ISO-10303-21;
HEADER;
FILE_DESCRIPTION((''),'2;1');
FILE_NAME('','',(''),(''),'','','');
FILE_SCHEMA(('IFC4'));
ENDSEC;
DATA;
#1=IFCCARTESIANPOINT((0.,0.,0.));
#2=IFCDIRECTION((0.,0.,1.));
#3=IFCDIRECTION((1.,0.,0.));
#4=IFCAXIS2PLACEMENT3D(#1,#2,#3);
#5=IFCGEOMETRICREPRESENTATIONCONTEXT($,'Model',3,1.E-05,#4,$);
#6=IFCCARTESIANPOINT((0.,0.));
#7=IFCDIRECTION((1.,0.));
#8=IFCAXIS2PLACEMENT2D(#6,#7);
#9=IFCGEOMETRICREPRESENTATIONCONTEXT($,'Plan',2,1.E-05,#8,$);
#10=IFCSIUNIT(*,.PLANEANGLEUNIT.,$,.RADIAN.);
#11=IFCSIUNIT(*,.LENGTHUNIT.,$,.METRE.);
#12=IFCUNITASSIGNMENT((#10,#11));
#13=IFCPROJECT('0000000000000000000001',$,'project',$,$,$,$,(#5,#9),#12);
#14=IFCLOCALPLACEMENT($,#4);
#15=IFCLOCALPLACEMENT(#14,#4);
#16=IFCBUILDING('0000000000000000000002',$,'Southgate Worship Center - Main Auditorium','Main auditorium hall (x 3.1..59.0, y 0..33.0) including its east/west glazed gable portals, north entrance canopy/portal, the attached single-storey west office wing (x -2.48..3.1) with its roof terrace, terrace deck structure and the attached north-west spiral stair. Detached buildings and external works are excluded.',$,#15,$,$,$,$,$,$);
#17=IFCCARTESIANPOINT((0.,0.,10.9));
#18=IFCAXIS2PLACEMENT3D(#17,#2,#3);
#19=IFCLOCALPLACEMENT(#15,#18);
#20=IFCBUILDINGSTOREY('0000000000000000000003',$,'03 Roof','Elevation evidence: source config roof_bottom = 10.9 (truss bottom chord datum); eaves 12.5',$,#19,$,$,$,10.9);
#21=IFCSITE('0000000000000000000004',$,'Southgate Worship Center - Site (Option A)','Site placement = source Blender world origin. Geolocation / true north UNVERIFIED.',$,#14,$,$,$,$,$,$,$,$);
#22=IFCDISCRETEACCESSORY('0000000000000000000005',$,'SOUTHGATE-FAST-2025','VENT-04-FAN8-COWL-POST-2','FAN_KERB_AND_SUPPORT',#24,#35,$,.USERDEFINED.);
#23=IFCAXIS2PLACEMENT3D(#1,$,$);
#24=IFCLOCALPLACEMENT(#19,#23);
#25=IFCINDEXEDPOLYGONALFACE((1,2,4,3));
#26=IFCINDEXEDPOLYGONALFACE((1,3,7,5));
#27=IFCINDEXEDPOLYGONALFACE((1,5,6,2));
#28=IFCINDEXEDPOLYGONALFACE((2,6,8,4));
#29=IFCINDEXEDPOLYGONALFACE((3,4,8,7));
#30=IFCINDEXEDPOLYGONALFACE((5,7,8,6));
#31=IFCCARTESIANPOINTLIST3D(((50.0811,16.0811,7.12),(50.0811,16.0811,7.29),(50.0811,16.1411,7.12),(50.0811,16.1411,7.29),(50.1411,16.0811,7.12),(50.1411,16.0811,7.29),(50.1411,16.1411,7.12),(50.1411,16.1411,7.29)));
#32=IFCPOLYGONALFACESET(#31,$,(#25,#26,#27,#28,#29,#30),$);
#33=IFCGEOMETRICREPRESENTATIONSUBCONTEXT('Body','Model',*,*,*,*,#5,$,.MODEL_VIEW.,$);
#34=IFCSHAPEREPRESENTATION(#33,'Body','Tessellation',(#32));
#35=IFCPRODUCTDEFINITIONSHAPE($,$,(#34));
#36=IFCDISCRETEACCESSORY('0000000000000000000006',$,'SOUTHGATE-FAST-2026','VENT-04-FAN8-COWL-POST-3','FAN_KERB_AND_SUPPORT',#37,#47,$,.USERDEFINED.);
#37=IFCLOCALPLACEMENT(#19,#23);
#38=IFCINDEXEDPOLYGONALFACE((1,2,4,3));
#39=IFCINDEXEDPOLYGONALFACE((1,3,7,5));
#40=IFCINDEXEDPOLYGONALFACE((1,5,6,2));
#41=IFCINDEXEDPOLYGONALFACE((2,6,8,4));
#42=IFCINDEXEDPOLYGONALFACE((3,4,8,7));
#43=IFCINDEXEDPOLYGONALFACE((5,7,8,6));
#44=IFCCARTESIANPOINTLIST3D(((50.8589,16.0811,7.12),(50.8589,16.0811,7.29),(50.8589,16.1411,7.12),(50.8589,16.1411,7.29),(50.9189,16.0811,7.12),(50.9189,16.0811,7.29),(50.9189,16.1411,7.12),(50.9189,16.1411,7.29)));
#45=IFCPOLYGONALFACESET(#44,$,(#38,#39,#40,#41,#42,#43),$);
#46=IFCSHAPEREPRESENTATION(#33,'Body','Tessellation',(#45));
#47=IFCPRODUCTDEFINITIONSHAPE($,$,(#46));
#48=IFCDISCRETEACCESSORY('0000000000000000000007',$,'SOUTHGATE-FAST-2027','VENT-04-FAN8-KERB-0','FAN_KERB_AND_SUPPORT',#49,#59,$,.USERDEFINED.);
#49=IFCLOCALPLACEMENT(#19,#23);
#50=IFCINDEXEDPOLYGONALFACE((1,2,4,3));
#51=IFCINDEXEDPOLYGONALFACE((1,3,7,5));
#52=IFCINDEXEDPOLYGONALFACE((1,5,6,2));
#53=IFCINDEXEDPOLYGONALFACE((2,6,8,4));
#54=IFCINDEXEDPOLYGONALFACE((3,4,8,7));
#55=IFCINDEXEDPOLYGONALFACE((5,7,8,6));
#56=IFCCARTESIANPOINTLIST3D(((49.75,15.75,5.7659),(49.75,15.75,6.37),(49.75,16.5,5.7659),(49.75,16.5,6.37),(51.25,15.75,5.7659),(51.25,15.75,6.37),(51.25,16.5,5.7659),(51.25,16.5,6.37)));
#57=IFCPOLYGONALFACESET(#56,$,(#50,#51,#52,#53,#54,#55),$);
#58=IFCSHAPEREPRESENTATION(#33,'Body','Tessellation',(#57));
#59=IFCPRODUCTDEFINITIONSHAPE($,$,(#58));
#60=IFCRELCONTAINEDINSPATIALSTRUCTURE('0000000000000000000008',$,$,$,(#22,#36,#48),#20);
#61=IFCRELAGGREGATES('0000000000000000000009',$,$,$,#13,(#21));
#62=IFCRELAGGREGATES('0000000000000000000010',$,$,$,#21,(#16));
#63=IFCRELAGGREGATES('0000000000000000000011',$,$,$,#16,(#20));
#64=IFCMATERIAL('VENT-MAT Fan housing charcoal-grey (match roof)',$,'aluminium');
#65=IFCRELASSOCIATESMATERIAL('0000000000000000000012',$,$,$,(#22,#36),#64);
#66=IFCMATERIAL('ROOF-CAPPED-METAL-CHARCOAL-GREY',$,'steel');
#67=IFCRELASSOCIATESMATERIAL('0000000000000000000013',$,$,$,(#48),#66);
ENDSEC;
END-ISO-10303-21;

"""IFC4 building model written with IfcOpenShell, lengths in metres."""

from ifc_helpers import new_model, si_unit, frame, origin_with_axes, origin_2d, origin_2d_with_axis, place, context, subcontext, project, spatial, rectangle, extrude, material, element, save


model = new_model("IFC4")

# Units and contexts
model_context = context("Model", 3, precision=1e-05, world=origin_with_axes())
plan_context = context("Plan", 2, precision=1e-05, world=origin_2d_with_axis())
body_context = subcontext(model_context, "Body", "Model", "MODEL_VIEW")
ifc_project = project(units=[si_unit("PLANEANGLEUNIT", "RADIAN"), si_unit("LENGTHUNIT", "METRE")], contexts=[model_context, plan_context])

# Site, building, storey
site_placement = place(None, origin_with_axes())
site = spatial("IfcSite", under=ifc_project, at=site_placement, Name="Southgate Worship Center - Site (Option A)", Description="Site placement = source Blender world origin. Geolocation / true north UNVERIFIED.")
building_placement = place(site_placement, origin_with_axes())
building = spatial("IfcBuilding", under=site, at=building_placement, Name="Southgate Worship Center - Main Auditorium", Description="Main auditorium hall (x 3.1..59.0, y 0..33.0) including its east/west glazed gable portals, north entrance canopy/portal, the attached single-storey west office wing (x -2.48..3.1) with its roof terrace, terrace deck structure and the attached north-west spiral stair. Detached buildings and external works are excluded.")
storey_placement = place(building_placement, frame((0.0, 0.0, 10.9), z_axis=(0.0, 0.0, 1.0), x_axis=(1.0, 0.0, 0.0)))
storey = spatial("IfcBuildingStorey", under=building, at=storey_placement, Name="03 Roof", Description="Elevation evidence: source config roof_bottom = 10.9 (truss bottom chord datum); eaves 12.5", Elevation=10.9)

# Discrete accessories
ifc_material_1 = material(Name="VENT-MAT Fan housing charcoal-grey (match roof)", Category="aluminium")
discrete_accessory_1_placement = place(storey_placement, frame((50.0811, 16.0811, 7.12), z_axis=(0.0, 0.0, 1.0), x_axis=(1.0, 0.0, 0.0)))
element("IfcDiscreteAccessory", 1, at=discrete_accessory_1_placement, inside=storey, material=ifc_material_1, Name="SOUTHGATE-FAST-2025", Description="VENT-04-FAN8-COWL-POST-2", ObjectType="FAN_KERB_AND_SUPPORT", PredefinedType="USERDEFINED", context=body_context, shape_type="SweptSolid", body=[
    extrude(rectangle(XDim=0.06, YDim=0.06, at=origin_2d()), frame((0.03, 0.03, 0.0), z_axis=(0.0, 0.0, 1.0), x_axis=(0.0, 1.0, 0.0)), (0.0, 0.0, 1.0), 0.17),
])
discrete_accessory_2_placement = place(storey_placement, frame((50.8589, 16.0811, 7.12), z_axis=(0.0, 0.0, 1.0), x_axis=(1.0, 0.0, 0.0)))
element("IfcDiscreteAccessory", 2, at=discrete_accessory_2_placement, inside=storey, material=ifc_material_1, Name="SOUTHGATE-FAST-2026", Description="VENT-04-FAN8-COWL-POST-3", ObjectType="FAN_KERB_AND_SUPPORT", PredefinedType="USERDEFINED", context=body_context, shape_type="SweptSolid", body=[
    extrude(rectangle(XDim=0.06, YDim=0.06, at=origin_2d()), frame((0.03, 0.03, 0.0), z_axis=(0.0, 0.0, 1.0), x_axis=(0.0, 1.0, 0.0)), (0.0, 0.0, 1.0), 0.17),
])
ifc_material_2 = material(Name="ROOF-CAPPED-METAL-CHARCOAL-GREY", Category="steel")
discrete_accessory_3_placement = place(storey_placement, frame((49.75, 15.75, 5.7659), z_axis=(0.0, 0.0, 1.0), x_axis=(1.0, 0.0, 0.0)))
element("IfcDiscreteAccessory", 3, at=discrete_accessory_3_placement, inside=storey, material=ifc_material_2, Name="SOUTHGATE-FAST-2027", Description="VENT-04-FAN8-KERB-0", ObjectType="FAN_KERB_AND_SUPPORT", PredefinedType="USERDEFINED", context=body_context, shape_type="SweptSolid", body=[
    extrude(rectangle(XDim=0.75, YDim=1.5, at=origin_2d()), frame((0.75, 0.375, 0.0), z_axis=(0.0, 0.0, 1.0), x_axis=(0.0, -1.0, 0.0)), (0.0, 0.0, 1.0), 0.6041),
])

save(model, "model.ifc")
